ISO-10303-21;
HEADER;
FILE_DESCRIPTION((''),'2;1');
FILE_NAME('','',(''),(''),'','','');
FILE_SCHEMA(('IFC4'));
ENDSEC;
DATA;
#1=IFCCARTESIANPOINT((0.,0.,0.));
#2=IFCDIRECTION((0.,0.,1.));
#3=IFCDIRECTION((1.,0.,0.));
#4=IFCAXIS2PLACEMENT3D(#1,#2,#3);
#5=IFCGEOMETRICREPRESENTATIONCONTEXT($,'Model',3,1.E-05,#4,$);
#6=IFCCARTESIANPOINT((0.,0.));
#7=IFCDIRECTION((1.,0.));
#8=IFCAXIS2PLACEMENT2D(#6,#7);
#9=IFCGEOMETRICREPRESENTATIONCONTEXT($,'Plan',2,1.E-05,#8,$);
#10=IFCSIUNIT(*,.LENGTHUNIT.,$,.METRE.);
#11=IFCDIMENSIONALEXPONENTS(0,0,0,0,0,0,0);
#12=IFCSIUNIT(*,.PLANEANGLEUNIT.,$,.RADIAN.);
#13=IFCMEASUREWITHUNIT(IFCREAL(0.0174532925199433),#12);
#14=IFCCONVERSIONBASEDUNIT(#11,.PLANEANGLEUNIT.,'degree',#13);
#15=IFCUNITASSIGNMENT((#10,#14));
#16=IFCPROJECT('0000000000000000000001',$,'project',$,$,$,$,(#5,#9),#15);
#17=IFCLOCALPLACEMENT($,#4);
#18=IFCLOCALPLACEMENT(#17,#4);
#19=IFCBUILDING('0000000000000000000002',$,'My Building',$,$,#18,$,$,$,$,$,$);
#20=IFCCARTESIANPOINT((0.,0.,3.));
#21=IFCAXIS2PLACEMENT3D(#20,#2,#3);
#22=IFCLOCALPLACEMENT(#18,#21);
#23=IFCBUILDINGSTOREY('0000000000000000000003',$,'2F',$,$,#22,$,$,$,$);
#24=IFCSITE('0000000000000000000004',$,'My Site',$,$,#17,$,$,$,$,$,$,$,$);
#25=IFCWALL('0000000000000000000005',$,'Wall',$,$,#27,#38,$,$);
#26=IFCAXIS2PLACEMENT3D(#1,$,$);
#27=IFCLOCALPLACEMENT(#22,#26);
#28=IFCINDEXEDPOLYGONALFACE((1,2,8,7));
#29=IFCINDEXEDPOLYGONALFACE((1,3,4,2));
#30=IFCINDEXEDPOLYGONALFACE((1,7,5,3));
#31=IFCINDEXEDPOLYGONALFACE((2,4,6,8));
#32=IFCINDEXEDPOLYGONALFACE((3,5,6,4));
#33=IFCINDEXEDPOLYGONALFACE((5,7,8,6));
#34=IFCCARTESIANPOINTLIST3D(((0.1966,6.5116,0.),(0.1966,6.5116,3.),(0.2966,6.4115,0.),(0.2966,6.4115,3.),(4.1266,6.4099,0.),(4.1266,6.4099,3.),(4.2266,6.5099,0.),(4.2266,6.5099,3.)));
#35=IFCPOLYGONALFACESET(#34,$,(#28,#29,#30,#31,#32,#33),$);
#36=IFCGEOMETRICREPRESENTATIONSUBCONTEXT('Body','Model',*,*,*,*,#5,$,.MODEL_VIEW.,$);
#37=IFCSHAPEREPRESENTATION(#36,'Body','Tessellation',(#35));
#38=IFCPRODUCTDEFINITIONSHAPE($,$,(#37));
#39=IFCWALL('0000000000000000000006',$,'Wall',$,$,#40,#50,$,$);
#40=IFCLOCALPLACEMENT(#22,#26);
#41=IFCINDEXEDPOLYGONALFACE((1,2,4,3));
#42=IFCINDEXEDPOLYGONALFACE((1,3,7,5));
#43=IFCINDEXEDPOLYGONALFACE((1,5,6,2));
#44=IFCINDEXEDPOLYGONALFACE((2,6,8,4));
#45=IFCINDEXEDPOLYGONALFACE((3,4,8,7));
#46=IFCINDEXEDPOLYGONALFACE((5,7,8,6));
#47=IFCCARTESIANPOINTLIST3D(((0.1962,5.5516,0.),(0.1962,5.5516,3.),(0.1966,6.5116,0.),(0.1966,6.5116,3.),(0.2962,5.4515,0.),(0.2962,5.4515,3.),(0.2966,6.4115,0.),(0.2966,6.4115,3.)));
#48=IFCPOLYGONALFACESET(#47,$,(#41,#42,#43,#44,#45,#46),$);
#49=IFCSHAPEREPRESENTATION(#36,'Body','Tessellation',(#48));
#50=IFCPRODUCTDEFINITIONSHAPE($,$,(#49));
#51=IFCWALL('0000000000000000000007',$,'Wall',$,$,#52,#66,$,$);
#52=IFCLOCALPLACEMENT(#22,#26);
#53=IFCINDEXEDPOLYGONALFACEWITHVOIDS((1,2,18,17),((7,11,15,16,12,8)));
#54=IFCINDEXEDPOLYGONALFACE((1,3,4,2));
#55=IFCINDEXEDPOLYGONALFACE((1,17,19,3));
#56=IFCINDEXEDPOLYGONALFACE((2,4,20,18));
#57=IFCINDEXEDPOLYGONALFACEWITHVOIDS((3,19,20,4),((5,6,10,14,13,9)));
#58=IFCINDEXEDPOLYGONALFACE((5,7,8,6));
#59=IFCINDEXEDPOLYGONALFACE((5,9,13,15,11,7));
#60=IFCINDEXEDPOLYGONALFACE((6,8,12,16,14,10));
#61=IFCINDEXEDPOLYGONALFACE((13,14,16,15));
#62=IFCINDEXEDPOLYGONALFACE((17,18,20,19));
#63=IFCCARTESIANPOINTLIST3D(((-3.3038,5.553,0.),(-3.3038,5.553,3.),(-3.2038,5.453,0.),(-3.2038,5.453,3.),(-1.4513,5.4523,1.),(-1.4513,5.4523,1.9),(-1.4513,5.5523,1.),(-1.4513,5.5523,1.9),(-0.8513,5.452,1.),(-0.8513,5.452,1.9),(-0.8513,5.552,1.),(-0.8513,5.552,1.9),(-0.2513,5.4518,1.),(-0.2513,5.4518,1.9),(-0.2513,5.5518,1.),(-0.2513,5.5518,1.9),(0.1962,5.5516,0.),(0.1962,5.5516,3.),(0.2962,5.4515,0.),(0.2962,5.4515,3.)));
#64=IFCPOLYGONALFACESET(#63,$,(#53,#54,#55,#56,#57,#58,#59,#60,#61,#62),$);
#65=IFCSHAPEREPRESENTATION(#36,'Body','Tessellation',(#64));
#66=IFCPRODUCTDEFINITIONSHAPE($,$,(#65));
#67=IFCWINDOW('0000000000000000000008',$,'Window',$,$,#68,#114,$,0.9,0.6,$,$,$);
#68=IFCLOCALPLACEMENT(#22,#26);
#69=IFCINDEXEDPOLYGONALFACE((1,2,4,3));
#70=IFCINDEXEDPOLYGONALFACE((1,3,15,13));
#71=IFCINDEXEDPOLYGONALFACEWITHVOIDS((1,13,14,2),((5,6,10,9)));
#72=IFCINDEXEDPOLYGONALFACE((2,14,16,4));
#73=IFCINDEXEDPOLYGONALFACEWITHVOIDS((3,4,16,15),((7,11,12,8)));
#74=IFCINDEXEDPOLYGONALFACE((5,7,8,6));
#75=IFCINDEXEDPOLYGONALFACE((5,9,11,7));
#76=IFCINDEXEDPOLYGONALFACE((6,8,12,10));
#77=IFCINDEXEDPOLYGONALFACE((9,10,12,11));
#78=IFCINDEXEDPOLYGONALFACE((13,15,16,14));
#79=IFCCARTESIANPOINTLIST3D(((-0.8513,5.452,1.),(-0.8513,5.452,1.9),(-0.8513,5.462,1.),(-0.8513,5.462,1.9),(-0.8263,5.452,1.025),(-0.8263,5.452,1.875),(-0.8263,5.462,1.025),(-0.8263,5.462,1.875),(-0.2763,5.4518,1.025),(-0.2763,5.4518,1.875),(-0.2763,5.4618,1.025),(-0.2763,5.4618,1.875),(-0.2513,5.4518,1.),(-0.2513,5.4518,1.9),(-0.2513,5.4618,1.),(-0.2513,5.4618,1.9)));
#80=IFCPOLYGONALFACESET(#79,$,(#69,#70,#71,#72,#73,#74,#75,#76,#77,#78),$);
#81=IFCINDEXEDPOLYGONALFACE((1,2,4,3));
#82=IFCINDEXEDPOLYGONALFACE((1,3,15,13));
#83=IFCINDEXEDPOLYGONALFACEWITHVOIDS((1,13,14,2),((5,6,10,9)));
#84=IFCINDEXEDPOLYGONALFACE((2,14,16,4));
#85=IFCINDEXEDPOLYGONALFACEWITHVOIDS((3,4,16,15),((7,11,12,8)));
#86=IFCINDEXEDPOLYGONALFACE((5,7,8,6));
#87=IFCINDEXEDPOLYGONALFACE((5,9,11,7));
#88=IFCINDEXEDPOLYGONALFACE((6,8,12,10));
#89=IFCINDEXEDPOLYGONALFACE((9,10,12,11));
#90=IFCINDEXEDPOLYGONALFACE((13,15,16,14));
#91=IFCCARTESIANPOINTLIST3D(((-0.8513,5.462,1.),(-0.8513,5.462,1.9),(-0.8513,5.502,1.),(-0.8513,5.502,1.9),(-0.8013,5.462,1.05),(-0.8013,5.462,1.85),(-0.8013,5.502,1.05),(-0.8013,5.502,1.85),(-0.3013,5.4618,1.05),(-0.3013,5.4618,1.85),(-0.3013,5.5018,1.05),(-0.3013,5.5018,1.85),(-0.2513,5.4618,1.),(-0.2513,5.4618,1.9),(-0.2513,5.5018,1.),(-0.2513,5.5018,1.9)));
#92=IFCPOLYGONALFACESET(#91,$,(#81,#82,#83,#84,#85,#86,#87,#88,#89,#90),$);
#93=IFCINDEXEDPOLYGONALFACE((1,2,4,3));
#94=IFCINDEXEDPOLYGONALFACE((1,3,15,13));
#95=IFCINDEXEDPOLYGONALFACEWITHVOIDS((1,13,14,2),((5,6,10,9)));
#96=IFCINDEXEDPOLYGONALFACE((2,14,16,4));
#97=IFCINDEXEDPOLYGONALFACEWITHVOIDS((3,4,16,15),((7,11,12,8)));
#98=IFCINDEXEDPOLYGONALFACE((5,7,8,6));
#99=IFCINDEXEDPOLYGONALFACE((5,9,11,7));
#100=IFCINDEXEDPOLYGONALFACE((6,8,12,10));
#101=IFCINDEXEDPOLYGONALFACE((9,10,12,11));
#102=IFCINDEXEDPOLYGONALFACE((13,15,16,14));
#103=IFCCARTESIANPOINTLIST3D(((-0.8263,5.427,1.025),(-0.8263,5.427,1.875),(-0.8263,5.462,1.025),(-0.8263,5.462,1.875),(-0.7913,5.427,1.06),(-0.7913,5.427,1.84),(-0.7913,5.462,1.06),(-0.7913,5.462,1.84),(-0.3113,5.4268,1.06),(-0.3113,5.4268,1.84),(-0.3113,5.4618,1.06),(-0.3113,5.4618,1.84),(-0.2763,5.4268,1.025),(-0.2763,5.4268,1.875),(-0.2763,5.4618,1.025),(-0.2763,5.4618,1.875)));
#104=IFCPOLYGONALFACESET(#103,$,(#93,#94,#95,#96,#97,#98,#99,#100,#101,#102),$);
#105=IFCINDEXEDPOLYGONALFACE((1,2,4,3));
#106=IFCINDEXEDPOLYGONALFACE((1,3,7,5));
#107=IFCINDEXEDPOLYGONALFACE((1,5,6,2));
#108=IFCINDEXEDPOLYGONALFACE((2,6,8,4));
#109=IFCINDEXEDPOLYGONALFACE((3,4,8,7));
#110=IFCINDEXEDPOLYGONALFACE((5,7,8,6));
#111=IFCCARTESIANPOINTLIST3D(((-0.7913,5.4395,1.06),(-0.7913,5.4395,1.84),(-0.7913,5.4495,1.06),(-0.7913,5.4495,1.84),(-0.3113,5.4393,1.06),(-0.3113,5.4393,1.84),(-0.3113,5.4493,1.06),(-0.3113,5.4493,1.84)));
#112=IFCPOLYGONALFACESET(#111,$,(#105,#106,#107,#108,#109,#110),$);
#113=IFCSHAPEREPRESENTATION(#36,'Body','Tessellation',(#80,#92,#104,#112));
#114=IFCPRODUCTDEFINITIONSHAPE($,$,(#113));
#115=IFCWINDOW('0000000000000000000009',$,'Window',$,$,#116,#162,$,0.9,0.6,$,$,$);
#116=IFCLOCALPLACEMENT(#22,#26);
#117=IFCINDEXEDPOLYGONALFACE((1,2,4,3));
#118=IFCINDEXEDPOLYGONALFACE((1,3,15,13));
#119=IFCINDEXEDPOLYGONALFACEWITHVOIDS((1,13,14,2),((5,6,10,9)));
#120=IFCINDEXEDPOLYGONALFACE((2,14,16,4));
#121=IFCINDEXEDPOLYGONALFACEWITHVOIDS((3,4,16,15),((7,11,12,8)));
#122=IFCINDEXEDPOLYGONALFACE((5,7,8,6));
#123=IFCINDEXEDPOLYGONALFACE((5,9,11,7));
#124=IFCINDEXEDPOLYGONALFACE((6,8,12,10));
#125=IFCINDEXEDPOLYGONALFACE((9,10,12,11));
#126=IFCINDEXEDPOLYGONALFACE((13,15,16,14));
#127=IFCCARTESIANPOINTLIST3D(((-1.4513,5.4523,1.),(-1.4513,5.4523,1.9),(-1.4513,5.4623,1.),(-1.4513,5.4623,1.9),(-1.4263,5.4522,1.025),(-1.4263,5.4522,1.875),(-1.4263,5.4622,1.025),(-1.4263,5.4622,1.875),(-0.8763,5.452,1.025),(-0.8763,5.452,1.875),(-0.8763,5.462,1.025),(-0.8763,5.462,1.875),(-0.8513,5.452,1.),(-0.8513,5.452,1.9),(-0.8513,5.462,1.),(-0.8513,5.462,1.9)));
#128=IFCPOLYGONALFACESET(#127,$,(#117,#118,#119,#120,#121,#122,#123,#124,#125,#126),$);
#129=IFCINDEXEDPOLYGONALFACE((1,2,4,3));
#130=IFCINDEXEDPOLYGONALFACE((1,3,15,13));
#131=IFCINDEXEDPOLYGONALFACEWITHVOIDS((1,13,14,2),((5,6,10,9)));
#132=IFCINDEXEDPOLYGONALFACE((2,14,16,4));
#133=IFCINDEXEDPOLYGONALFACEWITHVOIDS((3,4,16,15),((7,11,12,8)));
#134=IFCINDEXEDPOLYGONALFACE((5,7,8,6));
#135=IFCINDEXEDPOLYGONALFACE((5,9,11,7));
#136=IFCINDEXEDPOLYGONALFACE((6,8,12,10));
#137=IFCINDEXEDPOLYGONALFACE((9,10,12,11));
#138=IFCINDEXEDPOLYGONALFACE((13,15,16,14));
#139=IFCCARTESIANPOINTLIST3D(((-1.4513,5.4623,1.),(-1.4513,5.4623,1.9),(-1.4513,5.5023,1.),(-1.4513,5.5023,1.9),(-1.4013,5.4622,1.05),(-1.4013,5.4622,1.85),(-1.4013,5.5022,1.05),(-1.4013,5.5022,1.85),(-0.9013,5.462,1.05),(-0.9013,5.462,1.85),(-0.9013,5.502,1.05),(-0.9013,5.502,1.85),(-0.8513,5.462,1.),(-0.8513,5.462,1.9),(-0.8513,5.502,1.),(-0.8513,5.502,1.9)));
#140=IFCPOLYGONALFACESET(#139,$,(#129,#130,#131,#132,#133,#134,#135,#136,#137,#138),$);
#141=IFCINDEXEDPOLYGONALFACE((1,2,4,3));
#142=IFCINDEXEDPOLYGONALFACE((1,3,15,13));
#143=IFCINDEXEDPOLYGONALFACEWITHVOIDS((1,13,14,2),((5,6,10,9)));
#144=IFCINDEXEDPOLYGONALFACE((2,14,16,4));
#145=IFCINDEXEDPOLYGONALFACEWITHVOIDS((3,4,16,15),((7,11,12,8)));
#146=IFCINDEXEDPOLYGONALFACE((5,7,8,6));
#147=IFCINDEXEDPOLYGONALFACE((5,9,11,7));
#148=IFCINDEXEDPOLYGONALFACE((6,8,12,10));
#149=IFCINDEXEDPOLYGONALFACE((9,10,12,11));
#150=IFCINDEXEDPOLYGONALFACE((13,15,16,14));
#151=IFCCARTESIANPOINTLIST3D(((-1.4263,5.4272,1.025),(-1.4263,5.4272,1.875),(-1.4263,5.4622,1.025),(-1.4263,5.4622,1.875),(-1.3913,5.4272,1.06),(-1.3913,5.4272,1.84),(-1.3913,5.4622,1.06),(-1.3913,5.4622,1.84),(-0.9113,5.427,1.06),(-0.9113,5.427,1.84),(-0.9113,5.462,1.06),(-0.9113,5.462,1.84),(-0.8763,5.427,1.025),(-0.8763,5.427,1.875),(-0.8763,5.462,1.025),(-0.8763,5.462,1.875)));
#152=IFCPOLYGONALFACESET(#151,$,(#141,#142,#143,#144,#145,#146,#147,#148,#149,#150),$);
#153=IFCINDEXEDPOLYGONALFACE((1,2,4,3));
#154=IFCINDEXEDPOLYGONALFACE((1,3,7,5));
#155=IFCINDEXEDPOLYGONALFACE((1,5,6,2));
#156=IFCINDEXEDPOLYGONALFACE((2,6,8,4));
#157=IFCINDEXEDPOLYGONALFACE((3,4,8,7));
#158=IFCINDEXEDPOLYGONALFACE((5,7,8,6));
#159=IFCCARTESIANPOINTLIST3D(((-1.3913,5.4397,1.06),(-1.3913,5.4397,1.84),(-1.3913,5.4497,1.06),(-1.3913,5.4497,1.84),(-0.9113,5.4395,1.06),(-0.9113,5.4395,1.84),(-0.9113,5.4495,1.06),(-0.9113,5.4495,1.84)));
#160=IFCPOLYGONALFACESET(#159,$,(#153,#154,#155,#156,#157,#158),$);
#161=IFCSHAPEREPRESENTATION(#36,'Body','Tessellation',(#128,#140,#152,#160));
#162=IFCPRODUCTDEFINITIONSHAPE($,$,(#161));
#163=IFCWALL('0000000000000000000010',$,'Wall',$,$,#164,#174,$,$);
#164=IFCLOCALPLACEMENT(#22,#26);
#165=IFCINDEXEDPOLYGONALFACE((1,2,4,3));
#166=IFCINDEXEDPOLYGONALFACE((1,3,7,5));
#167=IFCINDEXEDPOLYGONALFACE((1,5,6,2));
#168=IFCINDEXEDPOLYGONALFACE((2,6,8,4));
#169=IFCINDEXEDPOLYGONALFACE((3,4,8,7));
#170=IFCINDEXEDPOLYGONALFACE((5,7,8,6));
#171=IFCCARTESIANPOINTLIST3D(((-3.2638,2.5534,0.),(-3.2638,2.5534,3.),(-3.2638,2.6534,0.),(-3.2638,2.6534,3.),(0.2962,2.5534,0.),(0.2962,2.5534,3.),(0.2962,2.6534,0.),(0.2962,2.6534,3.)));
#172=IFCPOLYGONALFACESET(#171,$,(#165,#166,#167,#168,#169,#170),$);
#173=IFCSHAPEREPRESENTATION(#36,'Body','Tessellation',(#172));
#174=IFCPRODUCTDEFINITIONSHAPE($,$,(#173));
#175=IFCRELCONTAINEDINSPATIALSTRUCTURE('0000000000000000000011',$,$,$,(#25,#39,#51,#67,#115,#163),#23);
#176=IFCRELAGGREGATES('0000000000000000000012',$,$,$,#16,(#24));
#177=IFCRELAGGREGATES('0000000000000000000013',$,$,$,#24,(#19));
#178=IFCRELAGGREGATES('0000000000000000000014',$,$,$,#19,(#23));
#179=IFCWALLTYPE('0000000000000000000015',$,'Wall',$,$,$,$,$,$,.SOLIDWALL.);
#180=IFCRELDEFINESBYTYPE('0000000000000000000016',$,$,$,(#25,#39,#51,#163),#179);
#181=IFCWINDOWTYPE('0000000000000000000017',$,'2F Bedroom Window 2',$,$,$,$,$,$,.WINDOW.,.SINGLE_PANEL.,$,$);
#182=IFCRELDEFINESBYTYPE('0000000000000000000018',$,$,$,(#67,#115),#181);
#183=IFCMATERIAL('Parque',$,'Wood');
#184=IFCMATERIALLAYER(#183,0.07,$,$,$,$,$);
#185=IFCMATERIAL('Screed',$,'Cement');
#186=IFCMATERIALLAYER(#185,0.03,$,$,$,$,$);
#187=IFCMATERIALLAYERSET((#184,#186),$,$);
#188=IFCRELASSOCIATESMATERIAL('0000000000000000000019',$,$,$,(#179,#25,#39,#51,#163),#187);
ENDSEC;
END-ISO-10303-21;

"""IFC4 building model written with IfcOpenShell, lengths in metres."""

from ifc_helpers import new_model, entity, si_unit, converted_unit, frame, origin_with_axes, origin_2d_with_axis, place, context, subcontext, project, spatial, line, indexed_curve, outline, extrude, shape, source, transform, mapped, material, layer, layer_set, layer_usage, type_object, type_shapes, element, fill, save


model = new_model("IFC4")

# Units and contexts
model_context = context("Model", 3, precision=1e-05, world=origin_with_axes())
plan_context = context("Plan", 2, precision=1e-05, world=origin_2d_with_axis())
body_context_1 = subcontext(model_context, "Body", "Model", "MODEL_VIEW")
body_context_2 = subcontext(plan_context, "Body", "Plan", "PLAN_VIEW")
ifc_project = project(units=[si_unit("LENGTHUNIT", "METRE"), converted_unit("PLANEANGLEUNIT", "degree", entity("IfcReal", 0.0174532925199433), si_unit("PLANEANGLEUNIT", "RADIAN"), dimensions=[0, 0, 0, 0, 0, 0, 0])], contexts=[model_context, plan_context])

# Site, building, storey
site_placement = place(None, origin_with_axes())
site = spatial("IfcSite", under=ifc_project, at=site_placement, Name="My Site")
building_placement = place(site_placement, origin_with_axes())
building = spatial("IfcBuilding", under=site, at=building_placement, Name="My Building")
storey_placement = place(building_placement, frame((0.0, 0.0, 3.0), z_axis=(0.0, 0.0, 1.0), x_axis=(1.0, 0.0, 0.0)))
storey = spatial("IfcBuildingStorey", under=building, at=storey_placement, Name="2F")

# Walls
ifc_material_1 = material(Name="Parque", Category="Wood")
ifc_layer_1 = layer(ifc_material_1, 0.07)
ifc_material_2 = material(Name="Screed", Category="Cement")
ifc_layer_2 = layer(ifc_material_2, 0.03)
ifc_layer_set = layer_set([ifc_layer_1, ifc_layer_2])
ifc_layer_usage_1 = layer_usage(ifc_layer_set, "AXIS2", "POSITIVE", 0.0)
wall_type = type_object("IfcWallType", Name="Wall", PredefinedType="SOLIDWALL", material=ifc_layer_set)
wall_1_placement = place(storey_placement, frame((4.2266, 6.5099, 0.0), z_axis=(0.0, 0.0, 1.0), x_axis=(-1.0, 0.000415, 0.0)))
element("IfcWall", 1, at=wall_1_placement, inside=storey, type_object=wall_type, material=ifc_layer_usage_1, Name="Wall", context=body_context_1, shape_type="SweptSolid", body=[
    extrude(outline(indexed_curve([(0.0, 0.0), (0.1, 0.1), (3.93, 0.1), (4.03, 0.0)], segments=[line(1, 2, 3, 4, 1)])), origin_with_axes(), (0.0, 0.0, 1.0), 3.0),
])
ifc_layer_usage_2 = layer_usage(ifc_layer_set, "AXIS2", "POSITIVE", 0.0)
wall_2_placement = place(storey_placement, frame((0.1966, 6.5116, 0.0), z_axis=(0.0, 0.0, 1.0), x_axis=(-0.000415, -1.0, 0.0)))
element("IfcWall", 2, at=wall_2_placement, inside=storey, type_object=wall_type, material=ifc_layer_usage_2, Name="Wall", context=body_context_1, shape_type="SweptSolid", body=[
    extrude(outline(indexed_curve([(0.0, 0.0), (0.1, 0.1), (1.06, 0.1), (0.96, 0.0)], segments=[line(1, 2, 3, 4, 1)])), origin_with_axes(), (0.0, 0.0, 1.0), 3.0),
])

# Wall, openings, windows
ifc_layer_usage_3 = layer_usage(ifc_layer_set, "AXIS2", "POSITIVE", 0.0)
wall_3_placement = place(storey_placement, frame((0.1962, 5.5516, 0.0), z_axis=(0.0, 0.0, 1.0), x_axis=(-1.0, 0.000416, 0.0)))
wall_3 = element("IfcWall", 3, at=wall_3_placement, inside=storey, type_object=wall_type, material=ifc_layer_usage_3, Name="Wall", context=body_context_1, shape_type="SweptSolid", body=[
    extrude(outline(indexed_curve([(0.0, 0.0), (-0.1, 0.1), (3.4, 0.1), (3.5, 0.0)], segments=[line(1, 2, 3, 4, 1)])), origin_with_axes(), (0.0, 0.0, 1.0), 3.0),
])
shared_shape_1 = source(origin_with_axes(), body_context_1, "Body", "SweptSolid", [
    extrude(outline(indexed_curve([(0.0, 0.0), (0.6, 0.0), (0.6, 0.9), (0.0, 0.9)], segments=[line(1, 2, 3, 4, 1)])), frame((0.0, -0.6, 0.0), z_axis=(0.0, -1.0, 0.0), x_axis=(1.0, 0.0, 0.0)), (0.0, 0.0, -1.0), 1.2),
])
opening_1_placement = place(wall_3_placement, frame((0.4475, 0.0, 1.0), z_axis=(0.0, 0.0, 1.0), x_axis=(1.0, 0.0, 0.0)))
opening_1 = element("IfcOpeningElement", 4, at=opening_1_placement, cuts=wall_3, PredefinedType="OPENING", context=body_context_1, shape_type="MappedRepresentation", body=[
    mapped(shared_shape_1, transform((0.0, 0.0, 0.0), x_axis=(1.0, 0.0, 0.0), y_axis=(0.0, 1.0, 0.0), z_axis=(0.0, 0.0, 1.0), scale=1.0)),
])
opening_2_placement = place(wall_3_placement, frame((1.0475, 0.0, 1.0), z_axis=(0.0, 0.0, 1.0), x_axis=(1.0, 0.0, 0.0)))
opening_2 = element("IfcOpeningElement", 5, at=opening_2_placement, cuts=wall_3, PredefinedType="OPENING", context=body_context_1, shape_type="MappedRepresentation", body=[
    mapped(shared_shape_1, transform((0.0, 0.0, 0.0), x_axis=(1.0, 0.0, 0.0), y_axis=(0.0, 1.0, 0.0), z_axis=(0.0, 0.0, 1.0), scale=1.0)),
])
window_type_1 = type_object("IfcWindowType", Name="2F Bedroom Window 2", PartitioningType="SINGLE_PANEL", PredefinedType="WINDOW")
shared_shape_2 = source(origin_with_axes(), body_context_1, "Body", "SweptSolid", [
    extrude(outline(indexed_curve([(0.0, 0.0), (0.6, 0.0), (0.6, 0.9), (0.0, 0.9)], segments=[line(1, 2, 3, 4, 1)]), holes=[indexed_curve([(0.025, 0.025), (0.575, 0.025), (0.575, 0.875), (0.025, 0.875)], segments=[line(1, 2, 3, 4, 1)])]), frame((0.0, 0.09, 0.0), z_axis=(0.0, -1.0, 0.0), x_axis=(1.0, 0.0, 0.0)), (0.0, 0.0, -1.0), 0.01),
    extrude(outline(indexed_curve([(0.0, 0.0), (0.6, 0.0), (0.6, 0.9), (0.0, 0.9)], segments=[line(1, 2, 3, 4, 1)]), holes=[indexed_curve([(0.05, 0.05), (0.55, 0.05), (0.55, 0.85), (0.05, 0.85)], segments=[line(1, 2, 3, 4, 1)])]), frame((0.0, 0.05, 0.0), z_axis=(0.0, -1.0, 0.0), x_axis=(1.0, 0.0, 0.0)), (0.0, 0.0, -1.0), 0.04),
    extrude(outline(indexed_curve([(0.0, 0.0), (0.55, 0.0), (0.55, 0.85), (0.0, 0.85)], segments=[line(1, 2, 3, 4, 1)]), holes=[indexed_curve([(0.035, 0.035), (0.515, 0.035), (0.515, 0.815), (0.035, 0.815)], segments=[line(1, 2, 3, 4, 1)])]), frame((0.025, 0.09, 0.025), z_axis=(0.0, -1.0, 0.0), x_axis=(1.0, 0.0, 0.0)), (0.0, 0.0, -1.0), 0.035),
    extrude(outline(indexed_curve([(0.035, 0.035), (0.515, 0.035), (0.515, 0.815), (0.035, 0.815)], segments=[line(1, 2, 3, 4, 1)])), frame((0.025, 0.1025, 0.025), z_axis=(0.0, -1.0, 0.0), x_axis=(1.0, 0.0, 0.0)), (0.0, 0.0, -1.0), 0.01),
])
shared_shape_3 = source(origin_with_axes(), body_context_2, "Body", "Curve2D", [
    entity("IfcIndexedPolyCurve", entity("IfcCartesianPointList2D", [[0.05, 0.05], [0.55, 0.05]])),
    entity("IfcIndexedPolyCurve", entity("IfcCartesianPointList2D", [[0.0, 0.1], [0.025, 0.1], [0.025, 0.09], [0.05, 0.09], [0.05, 0.05], [0.0, 0.05]]), [entity("IfcLineIndex", [1, 2, 3, 4, 5, 6, 1])]),
    entity("IfcIndexedPolyCurve", entity("IfcCartesianPointList2D", [[0.6, 0.1], [0.575, 0.1], [0.575, 0.09], [0.55, 0.09], [0.55, 0.05], [0.6, 0.05]]), [entity("IfcLineIndex", [1, 2, 3, 4, 5, 6, 1])]),
    entity("IfcIndexedPolyCurve", entity("IfcCartesianPointList2D", [[0.025, 0.09], [0.06, 0.09], [0.06, 0.125], [0.025, 0.125]]), [entity("IfcLineIndex", [1, 2, 3, 4, 1])]),
    entity("IfcIndexedPolyCurve", entity("IfcCartesianPointList2D", [[0.575, 0.09], [0.54, 0.09], [0.54, 0.125], [0.575, 0.125]]), [entity("IfcLineIndex", [1, 2, 3, 4, 1])]),
    entity("IfcIndexedPolyCurve", entity("IfcCartesianPointList2D", [[0.06, 0.09], [0.54, 0.09]])),
    entity("IfcIndexedPolyCurve", entity("IfcCartesianPointList2D", [[0.06, 0.125], [0.54, 0.125]])),
    entity("IfcIndexedPolyCurve", entity("IfcCartesianPointList2D", [[0.06, 0.1075], [0.54, 0.1075]])),
])
type_shapes(window_type_1, [shared_shape_2, shared_shape_3])
window_1_placement = place(opening_1_placement, frame((0.0, 0.0, 0.0), z_axis=(0.0, 0.0, 1.0), x_axis=(1.0, 0.0, 0.0)))
window_1 = element("IfcWindow", 6, at=window_1_placement, inside=storey, type_object=window_type_1, Name="Window", OverallHeight=0.9, OverallWidth=0.6, shapes=[
    shape(body_context_1, "Body", "MappedRepresentation", [mapped(shared_shape_2, transform((0.0, 0.0, 0.0), x_axis=(1.0, 0.0, 0.0), y_axis=(0.0, 1.0, 0.0), z_axis=(0.0, 0.0, 1.0), scale=1.0))]),
    shape(body_context_2, "Body", "MappedRepresentation", [mapped(shared_shape_3, transform((0.0, 0.0, 0.0), x_axis=(1.0, 0.0, 0.0), y_axis=(0.0, 1.0, 0.0), z_axis=(0.0, 0.0, 1.0), scale=1.0))]),
])
fill(opening_1, window_1)
window_2_placement = place(opening_2_placement, origin_with_axes())
window_2 = element("IfcWindow", 7, at=window_2_placement, inside=storey, type_object=window_type_1, Name="Window", OverallHeight=0.9, OverallWidth=0.6, shapes=[
    shape(body_context_1, "Body", "MappedRepresentation", [mapped(shared_shape_2, transform((0.0, 0.0, 0.0), x_axis=(1.0, 0.0, 0.0), y_axis=(0.0, 1.0, 0.0), z_axis=(0.0, 0.0, 1.0), scale=1.0))]),
    shape(body_context_2, "Body", "MappedRepresentation", [mapped(shared_shape_3, transform((0.0, 0.0, 0.0), x_axis=(1.0, 0.0, 0.0), y_axis=(0.0, 1.0, 0.0), z_axis=(0.0, 0.0, 1.0), scale=1.0))]),
])
fill(opening_2, window_2)

# Wall
ifc_layer_usage_4 = layer_usage(ifc_layer_set, "AXIS2", "POSITIVE", 0.0)
wall_4_placement = place(storey_placement, frame((-3.2638, 2.5534, 0.0), z_axis=(0.0, 0.0, 1.0), x_axis=(1.0, 0.0, 0.0)))
element("IfcWall", 8, at=wall_4_placement, inside=storey, type_object=wall_type, material=ifc_layer_usage_4, Name="Wall", context=body_context_1, shape_type="SweptSolid", body=[
    extrude(outline(indexed_curve([(0.0, 0.0), (0.0, 0.1), (3.56, 0.1), (3.56, 0.0)], segments=[line(1, 2, 3, 4, 1)])), origin_with_axes(), (0.0, 0.0, 1.0), 3.0),
])

save(model, "model.ifc")
